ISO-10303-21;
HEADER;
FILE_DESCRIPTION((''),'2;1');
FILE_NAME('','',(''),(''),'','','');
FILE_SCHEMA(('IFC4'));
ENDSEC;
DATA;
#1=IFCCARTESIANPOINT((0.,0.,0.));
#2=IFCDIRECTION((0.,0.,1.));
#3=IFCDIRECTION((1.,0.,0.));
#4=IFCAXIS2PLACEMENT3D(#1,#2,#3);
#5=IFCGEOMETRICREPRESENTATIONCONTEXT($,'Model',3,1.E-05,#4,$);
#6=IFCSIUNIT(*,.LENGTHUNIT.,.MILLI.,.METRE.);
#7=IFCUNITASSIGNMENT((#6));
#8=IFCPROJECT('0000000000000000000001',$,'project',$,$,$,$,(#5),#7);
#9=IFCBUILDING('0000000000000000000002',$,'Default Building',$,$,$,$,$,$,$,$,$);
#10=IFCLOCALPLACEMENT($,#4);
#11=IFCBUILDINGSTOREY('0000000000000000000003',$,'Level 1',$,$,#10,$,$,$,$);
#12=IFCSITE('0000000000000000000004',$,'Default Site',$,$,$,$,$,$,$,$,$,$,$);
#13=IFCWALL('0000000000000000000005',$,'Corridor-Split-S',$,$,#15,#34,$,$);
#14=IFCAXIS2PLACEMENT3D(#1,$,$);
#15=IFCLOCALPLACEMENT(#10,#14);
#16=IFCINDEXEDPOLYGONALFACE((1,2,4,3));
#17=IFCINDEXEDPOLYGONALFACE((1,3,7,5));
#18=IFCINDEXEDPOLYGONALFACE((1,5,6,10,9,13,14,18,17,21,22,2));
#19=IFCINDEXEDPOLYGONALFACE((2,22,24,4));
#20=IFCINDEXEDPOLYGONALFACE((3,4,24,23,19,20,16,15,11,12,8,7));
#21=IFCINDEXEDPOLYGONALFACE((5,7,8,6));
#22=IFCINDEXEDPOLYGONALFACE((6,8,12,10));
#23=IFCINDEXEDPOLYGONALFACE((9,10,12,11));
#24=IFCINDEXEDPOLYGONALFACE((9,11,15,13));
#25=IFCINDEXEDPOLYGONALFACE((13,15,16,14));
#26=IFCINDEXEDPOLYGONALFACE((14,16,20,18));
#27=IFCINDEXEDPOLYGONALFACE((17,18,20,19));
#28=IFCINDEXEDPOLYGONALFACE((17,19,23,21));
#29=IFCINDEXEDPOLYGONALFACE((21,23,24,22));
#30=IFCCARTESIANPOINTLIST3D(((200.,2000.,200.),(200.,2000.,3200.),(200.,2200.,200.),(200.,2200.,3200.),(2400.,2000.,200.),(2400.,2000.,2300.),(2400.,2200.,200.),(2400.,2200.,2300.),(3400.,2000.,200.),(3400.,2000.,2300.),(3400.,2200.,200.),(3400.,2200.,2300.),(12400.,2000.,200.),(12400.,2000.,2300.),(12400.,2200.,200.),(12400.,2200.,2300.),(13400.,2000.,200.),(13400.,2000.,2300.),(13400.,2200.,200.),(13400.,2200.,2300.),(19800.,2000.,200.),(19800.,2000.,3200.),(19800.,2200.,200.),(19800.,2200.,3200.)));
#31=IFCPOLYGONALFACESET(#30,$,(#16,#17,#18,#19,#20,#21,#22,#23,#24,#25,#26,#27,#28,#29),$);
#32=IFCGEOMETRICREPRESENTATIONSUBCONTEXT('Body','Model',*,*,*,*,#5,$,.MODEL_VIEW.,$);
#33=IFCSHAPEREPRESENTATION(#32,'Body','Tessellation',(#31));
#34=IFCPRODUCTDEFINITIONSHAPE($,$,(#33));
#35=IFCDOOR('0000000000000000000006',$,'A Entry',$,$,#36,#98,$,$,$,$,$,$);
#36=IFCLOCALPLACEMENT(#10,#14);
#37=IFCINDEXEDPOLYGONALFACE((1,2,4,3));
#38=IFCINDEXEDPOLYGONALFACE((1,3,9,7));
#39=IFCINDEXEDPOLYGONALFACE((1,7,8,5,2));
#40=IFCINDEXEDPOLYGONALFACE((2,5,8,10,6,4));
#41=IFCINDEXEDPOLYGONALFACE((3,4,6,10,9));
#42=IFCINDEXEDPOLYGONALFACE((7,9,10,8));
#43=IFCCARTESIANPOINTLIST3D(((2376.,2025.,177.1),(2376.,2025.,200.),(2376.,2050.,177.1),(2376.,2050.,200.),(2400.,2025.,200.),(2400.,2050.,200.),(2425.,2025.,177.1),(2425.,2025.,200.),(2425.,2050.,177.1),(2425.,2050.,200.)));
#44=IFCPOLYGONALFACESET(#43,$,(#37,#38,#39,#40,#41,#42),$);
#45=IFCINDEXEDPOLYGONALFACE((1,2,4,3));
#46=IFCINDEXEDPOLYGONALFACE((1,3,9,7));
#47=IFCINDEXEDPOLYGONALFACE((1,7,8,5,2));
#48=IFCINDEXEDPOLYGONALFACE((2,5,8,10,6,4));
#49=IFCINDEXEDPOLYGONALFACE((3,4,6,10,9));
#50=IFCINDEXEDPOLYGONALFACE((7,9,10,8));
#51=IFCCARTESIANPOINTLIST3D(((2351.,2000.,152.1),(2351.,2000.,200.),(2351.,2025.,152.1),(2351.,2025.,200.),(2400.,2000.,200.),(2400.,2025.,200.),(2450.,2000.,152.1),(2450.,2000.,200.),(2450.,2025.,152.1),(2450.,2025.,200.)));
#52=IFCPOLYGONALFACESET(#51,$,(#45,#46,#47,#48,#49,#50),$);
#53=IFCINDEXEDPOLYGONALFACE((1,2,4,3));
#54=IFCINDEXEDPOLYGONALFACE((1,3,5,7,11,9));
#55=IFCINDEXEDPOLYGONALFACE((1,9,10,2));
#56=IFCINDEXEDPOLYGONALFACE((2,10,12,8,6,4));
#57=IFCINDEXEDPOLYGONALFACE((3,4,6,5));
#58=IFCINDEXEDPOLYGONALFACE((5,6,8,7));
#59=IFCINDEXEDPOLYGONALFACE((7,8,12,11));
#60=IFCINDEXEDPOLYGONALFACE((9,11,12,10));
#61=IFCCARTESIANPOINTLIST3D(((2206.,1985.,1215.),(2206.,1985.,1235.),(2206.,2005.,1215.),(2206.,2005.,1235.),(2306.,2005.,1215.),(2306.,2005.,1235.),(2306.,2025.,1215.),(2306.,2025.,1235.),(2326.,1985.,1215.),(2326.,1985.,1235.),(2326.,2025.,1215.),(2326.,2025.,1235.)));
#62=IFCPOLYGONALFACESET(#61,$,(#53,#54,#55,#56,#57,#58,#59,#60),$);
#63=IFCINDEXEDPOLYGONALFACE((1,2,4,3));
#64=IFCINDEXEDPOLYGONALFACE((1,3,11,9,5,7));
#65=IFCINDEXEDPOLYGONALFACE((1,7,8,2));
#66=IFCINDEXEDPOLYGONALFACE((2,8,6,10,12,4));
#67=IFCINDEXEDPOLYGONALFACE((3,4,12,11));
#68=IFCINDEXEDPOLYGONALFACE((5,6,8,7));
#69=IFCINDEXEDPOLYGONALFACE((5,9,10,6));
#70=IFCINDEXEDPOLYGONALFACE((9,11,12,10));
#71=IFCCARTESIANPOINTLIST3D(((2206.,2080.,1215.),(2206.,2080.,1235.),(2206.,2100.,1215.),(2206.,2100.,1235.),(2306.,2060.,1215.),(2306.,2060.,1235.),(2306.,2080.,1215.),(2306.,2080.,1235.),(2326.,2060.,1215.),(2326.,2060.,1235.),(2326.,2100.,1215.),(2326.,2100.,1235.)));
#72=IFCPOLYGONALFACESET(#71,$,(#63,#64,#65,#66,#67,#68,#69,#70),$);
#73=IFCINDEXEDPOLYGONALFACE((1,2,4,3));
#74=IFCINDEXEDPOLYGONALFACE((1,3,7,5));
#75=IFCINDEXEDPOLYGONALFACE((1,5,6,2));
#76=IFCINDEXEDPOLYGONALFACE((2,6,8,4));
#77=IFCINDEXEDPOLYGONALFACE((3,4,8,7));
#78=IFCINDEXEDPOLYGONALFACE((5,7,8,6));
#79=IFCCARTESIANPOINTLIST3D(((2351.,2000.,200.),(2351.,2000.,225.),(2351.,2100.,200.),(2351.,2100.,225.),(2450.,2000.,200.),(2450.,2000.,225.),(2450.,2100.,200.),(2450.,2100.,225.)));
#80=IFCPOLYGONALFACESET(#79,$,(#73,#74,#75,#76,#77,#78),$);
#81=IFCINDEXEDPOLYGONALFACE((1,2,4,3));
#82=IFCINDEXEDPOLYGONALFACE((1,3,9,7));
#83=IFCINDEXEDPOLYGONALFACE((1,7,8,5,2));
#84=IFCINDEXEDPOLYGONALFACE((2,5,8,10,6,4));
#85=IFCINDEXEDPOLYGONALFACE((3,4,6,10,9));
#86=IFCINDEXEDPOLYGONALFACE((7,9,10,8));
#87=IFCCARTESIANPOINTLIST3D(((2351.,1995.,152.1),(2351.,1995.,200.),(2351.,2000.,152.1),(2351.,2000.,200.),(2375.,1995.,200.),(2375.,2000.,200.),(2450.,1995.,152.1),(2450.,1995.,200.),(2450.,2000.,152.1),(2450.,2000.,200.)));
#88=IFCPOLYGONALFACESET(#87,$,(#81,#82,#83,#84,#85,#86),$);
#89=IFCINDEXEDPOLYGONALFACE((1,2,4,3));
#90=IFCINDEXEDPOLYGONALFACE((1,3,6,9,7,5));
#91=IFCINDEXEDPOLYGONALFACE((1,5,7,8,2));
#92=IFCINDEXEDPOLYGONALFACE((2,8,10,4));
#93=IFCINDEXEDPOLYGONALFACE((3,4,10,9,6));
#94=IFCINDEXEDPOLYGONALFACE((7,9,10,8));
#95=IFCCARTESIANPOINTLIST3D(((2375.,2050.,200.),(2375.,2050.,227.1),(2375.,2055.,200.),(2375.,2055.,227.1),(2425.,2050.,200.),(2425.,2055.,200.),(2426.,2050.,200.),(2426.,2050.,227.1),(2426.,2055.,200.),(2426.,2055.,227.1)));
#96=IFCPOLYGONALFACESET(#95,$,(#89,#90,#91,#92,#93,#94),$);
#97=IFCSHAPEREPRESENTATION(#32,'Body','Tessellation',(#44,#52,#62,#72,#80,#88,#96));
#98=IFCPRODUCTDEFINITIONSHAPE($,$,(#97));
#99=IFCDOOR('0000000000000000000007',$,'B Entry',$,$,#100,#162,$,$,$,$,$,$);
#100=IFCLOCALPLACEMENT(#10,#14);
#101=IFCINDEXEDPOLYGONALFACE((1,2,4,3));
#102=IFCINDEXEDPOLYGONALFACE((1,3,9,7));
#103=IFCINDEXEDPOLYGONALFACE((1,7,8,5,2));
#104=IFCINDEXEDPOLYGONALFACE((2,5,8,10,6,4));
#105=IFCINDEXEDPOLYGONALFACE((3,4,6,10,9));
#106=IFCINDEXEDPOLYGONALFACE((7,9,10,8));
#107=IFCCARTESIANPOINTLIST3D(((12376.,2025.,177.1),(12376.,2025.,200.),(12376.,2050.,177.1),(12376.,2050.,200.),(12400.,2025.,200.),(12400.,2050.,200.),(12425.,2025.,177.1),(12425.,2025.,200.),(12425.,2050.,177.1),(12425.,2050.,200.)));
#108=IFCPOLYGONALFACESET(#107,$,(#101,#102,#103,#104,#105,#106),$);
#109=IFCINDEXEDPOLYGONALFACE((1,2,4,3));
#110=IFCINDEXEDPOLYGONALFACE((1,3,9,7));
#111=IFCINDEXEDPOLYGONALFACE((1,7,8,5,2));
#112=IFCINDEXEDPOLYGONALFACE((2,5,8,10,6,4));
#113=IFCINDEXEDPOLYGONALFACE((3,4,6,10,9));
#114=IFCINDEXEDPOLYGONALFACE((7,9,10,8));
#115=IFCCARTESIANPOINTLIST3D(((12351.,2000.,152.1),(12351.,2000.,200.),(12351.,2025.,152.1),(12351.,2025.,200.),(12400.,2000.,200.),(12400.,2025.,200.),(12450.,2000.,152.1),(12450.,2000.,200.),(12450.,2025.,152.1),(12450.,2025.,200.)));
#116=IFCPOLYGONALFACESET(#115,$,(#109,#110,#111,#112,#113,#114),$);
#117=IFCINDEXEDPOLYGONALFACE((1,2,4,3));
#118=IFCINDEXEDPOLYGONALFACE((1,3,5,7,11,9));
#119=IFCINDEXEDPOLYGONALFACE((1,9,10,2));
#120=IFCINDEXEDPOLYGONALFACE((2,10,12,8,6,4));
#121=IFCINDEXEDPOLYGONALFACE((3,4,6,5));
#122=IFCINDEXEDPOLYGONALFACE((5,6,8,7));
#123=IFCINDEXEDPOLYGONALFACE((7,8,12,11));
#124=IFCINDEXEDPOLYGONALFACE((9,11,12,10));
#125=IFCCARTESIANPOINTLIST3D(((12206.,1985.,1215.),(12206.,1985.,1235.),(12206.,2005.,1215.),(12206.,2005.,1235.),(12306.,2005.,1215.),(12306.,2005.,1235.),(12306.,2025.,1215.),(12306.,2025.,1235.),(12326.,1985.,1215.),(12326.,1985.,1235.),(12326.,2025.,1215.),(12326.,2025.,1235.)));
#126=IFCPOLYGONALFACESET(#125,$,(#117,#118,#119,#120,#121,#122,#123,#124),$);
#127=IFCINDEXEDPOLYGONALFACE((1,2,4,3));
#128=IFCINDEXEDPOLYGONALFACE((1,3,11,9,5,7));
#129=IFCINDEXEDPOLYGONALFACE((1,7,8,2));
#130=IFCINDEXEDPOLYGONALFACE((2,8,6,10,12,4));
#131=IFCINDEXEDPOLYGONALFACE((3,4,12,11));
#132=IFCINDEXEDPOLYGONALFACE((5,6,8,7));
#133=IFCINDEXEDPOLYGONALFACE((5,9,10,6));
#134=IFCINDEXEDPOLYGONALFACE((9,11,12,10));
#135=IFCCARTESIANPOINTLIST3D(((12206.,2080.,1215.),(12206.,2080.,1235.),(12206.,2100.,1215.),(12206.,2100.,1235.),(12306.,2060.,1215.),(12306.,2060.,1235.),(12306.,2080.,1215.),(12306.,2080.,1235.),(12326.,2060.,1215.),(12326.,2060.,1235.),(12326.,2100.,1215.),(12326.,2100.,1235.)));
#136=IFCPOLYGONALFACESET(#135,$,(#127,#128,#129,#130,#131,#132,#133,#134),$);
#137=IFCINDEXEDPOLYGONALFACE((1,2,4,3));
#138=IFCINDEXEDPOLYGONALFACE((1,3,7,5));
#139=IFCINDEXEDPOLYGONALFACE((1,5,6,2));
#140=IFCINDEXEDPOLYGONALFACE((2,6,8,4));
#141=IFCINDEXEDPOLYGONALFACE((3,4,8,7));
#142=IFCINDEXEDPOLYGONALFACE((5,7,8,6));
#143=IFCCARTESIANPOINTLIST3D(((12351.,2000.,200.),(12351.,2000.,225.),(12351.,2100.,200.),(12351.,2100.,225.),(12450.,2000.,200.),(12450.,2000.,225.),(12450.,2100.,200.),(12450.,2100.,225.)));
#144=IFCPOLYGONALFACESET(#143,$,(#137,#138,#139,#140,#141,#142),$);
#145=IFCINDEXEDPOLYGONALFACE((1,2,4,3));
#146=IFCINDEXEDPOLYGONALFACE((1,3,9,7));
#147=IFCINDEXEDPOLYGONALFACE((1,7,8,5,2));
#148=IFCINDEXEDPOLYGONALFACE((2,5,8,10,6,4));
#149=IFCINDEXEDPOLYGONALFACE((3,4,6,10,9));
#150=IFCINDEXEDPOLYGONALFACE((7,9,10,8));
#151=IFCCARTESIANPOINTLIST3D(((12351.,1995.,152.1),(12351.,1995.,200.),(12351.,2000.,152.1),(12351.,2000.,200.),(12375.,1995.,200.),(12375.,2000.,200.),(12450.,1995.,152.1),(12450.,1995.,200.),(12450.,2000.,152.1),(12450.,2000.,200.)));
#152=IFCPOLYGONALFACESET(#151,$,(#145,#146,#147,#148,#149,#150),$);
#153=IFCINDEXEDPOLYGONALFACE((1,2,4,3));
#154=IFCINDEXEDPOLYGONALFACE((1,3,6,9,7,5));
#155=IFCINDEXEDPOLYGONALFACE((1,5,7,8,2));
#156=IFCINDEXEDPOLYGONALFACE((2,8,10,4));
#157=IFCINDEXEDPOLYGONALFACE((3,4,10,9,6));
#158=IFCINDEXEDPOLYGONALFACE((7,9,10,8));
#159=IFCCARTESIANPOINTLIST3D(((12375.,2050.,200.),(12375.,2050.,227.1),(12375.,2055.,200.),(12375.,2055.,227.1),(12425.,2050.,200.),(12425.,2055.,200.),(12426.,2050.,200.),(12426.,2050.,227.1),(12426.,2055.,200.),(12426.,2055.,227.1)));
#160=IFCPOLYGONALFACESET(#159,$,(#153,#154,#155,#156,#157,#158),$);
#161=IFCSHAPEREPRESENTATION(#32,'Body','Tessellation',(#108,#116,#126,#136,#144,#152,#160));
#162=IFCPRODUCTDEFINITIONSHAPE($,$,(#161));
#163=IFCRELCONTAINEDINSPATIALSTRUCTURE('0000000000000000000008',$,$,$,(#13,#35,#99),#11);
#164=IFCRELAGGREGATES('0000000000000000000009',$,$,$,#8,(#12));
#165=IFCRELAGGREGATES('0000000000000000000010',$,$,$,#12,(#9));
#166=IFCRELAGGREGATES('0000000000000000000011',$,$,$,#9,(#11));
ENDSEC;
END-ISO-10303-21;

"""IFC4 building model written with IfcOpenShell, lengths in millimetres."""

from ifc_helpers import new_model, si_unit, frame, origin_with_axes, place, context, subcontext, project, spatial, line, indexed_curve, outline, extrude, element, fill, save


model = new_model("IFC4")

# Units and contexts
model_context = context("Model", 3, precision=1e-05, world=origin_with_axes())
body_context = subcontext(model_context, "Body", "Model", "MODEL_VIEW")
ifc_project = project(units=[si_unit("LENGTHUNIT", "METRE", prefix="MILLI")], contexts=[model_context])

# Site, building, storey
site = spatial("IfcSite", under=ifc_project, Name="Default Site")
building = spatial("IfcBuilding", under=site, Name="Default Building")
storey_placement = place(None, origin_with_axes())
storey = spatial("IfcBuildingStorey", under=building, at=storey_placement, Name="Level 1")

# Wall, openings, doors
wall_1_placement = place(storey_placement, frame((0.0, 0.0, 200.0), z_axis=(0.0, 0.0, 1.0), x_axis=(1.0, 0.0, 0.0)))
wall_1 = element("IfcWall", 1, at=wall_1_placement, inside=storey, Name="Corridor-Split-S", context=body_context, shape_type="SweptSolid", body=[
    extrude(outline(indexed_curve([(200.0, 2000.0), (19800.0, 2000.0), (19800.0, 2200.0), (200.0, 2200.0), (200.0, 2000.0)])), None, (0.0, 0.0, 1.0), 3000.0),
])
opening_1_placement = place(wall_1_placement, origin_with_axes())
opening_1 = element("IfcOpeningElement", 2, at=opening_1_placement, cuts=wall_1, context=body_context, shape_type="SweptSolid", body=[
    extrude(outline(indexed_curve([(2400.0, 2000.0), (3400.0, 2000.0), (3400.0, 2200.0), (2400.0, 2200.0), (2400.0, 2000.0)])), None, (0.0, 0.0, 1.0), 2100.0),
])
opening_2_placement = place(wall_1_placement, origin_with_axes())
opening_2 = element("IfcOpeningElement", 3, at=opening_2_placement, cuts=wall_1, context=body_context, shape_type="SweptSolid", body=[
    extrude(outline(indexed_curve([(12400.0, 2000.0), (13400.0, 2000.0), (13400.0, 2200.0), (12400.0, 2200.0), (12400.0, 2000.0)])), None, (0.0, 0.0, 1.0), 2100.0),
])
door_1_placement = place(storey_placement, frame((2400.0, 2000.0, 200.0), z_axis=(0.0, 0.0, 1.0), x_axis=(1.0, 0.0, 0.0)))
door_1 = element("IfcDoor", 4, at=door_1_placement, inside=storey, Name="A Entry", context=body_context, shape_type="SweptSolid", body=[
    extrude(outline(indexed_curve([(0.0, 0.0), (0.0, 2.1), (1.0, 2.1), (1.0, 0.0), (-24.0, 0.0), (-24.0, -22.9), (25.0, -22.9), (25.0, 0.0)], segments=[line(1, 2, 3, 4, 5, 6, 7, 8, 1)])), frame((0.0, 25.0, 0.0), z_axis=(0.0, -1.0, 0.0), x_axis=(1.0, 0.0, 0.0)), (0.0, 0.0, -1.0), 25.0),
    extrude(outline(indexed_curve([(0.0, 0.0), (0.0, 2.1), (1.0, 2.1), (1.0, 0.0), (-49.0, 0.0), (-49.0, -47.9), (50.0, -47.9), (50.0, 0.0)], segments=[line(1, 2, 3, 4, 5, 6, 7, 8, 1)])), frame((0.0, 0.0, 0.0), z_axis=(0.0, -1.0, 0.0), x_axis=(1.0, 0.0, 0.0)), (0.0, 0.0, -1.0), 25.0),
    extrude(outline(indexed_curve([(0.0, 0.0), (-49.0, 0.0), (-49.0, 35.0), (0.0, 35.0)], segments=[line(1, 2, 3, 4, 1)])), frame((25.0, 25.0, 25.0), z_axis=(0.0, 0.0, 1.0), x_axis=(1.0, 0.0, 0.0)), (0.0, 0.0, 1.0), -47.9),
    extrude(outline(indexed_curve([(0.0, 0.0), (0.0, -40.0), (-120.0, -40.0), (-120.0, -20.0), (-20.0, -20.0), (-20.0, 0.0)], segments=[line(1, 2, 3, 4, 5, 6, 1)])), frame((-74.0, 25.0, 1015.0), z_axis=(0.0, 0.0, 1.0), x_axis=(1.0, 0.0, 0.0)), (0.0, 0.0, 1.0), 20.0),
    extrude(outline(indexed_curve([(0.0, 0.0), (0.0, 40.0), (-120.0, 40.0), (-120.0, 20.0), (-20.0, 20.0), (-20.0, 0.0)], segments=[line(1, 2, 3, 4, 5, 6, 1)])), frame((-74.0, 60.0, 1015.0), z_axis=(0.0, 0.0, 1.0), x_axis=(1.0, 0.0, 0.0)), (0.0, 0.0, 1.0), 20.0),
    extrude(outline(indexed_curve([(0.0, 0.0), (-99.0, 0.0), (-99.0, 100.0), (0.0, 100.0)], segments=[line(1, 2, 3, 4, 1)])), frame((50.0, 0.0, 0.0), z_axis=(0.0, 0.0, 1.0), x_axis=(1.0, 0.0, 0.0)), (0.0, 0.0, 1.0), 25.0),
    extrude(outline(indexed_curve([(0.0, 0.0), (0.0, 27.1), (51.0, 27.1), (51.0, 0.0), (-24.0, 0.0), (-24.0, -47.9), (75.0, -47.9), (75.0, 0.0)], segments=[line(1, 2, 3, 4, 5, 6, 7, 8, 1)])), frame((-25.0, -5.0, 0.0), z_axis=(0.0, -1.0, 0.0), x_axis=(1.0, 0.0, 0.0)), (0.0, 0.0, -1.0), 5.0),
    extrude(outline(indexed_curve([(0.0, 0.0), (0.0, 27.1), (51.0, 27.1), (51.0, 0.0), (1.0, 0.0), (1.0, -22.9), (50.0, -22.9), (50.0, 0.0)], segments=[line(1, 2, 3, 4, 5, 6, 7, 8, 1)])), frame((-25.0, 50.0, 0.0), z_axis=(0.0, -1.0, 0.0), x_axis=(1.0, 0.0, 0.0)), (0.0, 0.0, -1.0), 5.0),
])
fill(opening_1, door_1)
door_2_placement = place(storey_placement, frame((12400.0, 2000.0, 200.0), z_axis=(0.0, 0.0, 1.0), x_axis=(1.0, 0.0, 0.0)))
door_2 = element("IfcDoor", 5, at=door_2_placement, inside=storey, Name="B Entry", context=body_context, shape_type="SweptSolid", body=[
    extrude(outline(indexed_curve([(0.0, 0.0), (0.0, 2.1), (1.0, 2.1), (1.0, 0.0), (-24.0, 0.0), (-24.0, -22.9), (25.0, -22.9), (25.0, 0.0)], segments=[line(1, 2, 3, 4, 5, 6, 7, 8, 1)])), frame((0.0, 25.0, 0.0), z_axis=(0.0, -1.0, 0.0), x_axis=(1.0, 0.0, 0.0)), (0.0, 0.0, -1.0), 25.0),
    extrude(outline(indexed_curve([(0.0, 0.0), (0.0, 2.1), (1.0, 2.1), (1.0, 0.0), (-49.0, 0.0), (-49.0, -47.9), (50.0, -47.9), (50.0, 0.0)], segments=[line(1, 2, 3, 4, 5, 6, 7, 8, 1)])), frame((0.0, 0.0, 0.0), z_axis=(0.0, -1.0, 0.0), x_axis=(1.0, 0.0, 0.0)), (0.0, 0.0, -1.0), 25.0),
    extrude(outline(indexed_curve([(0.0, 0.0), (-49.0, 0.0), (-49.0, 35.0), (0.0, 35.0)], segments=[line(1, 2, 3, 4, 1)])), frame((25.0, 25.0, 25.0), z_axis=(0.0, 0.0, 1.0), x_axis=(1.0, 0.0, 0.0)), (0.0, 0.0, 1.0), -47.9),
    extrude(outline(indexed_curve([(0.0, 0.0), (0.0, -40.0), (-120.0, -40.0), (-120.0, -20.0), (-20.0, -20.0), (-20.0, 0.0)], segments=[line(1, 2, 3, 4, 5, 6, 1)])), frame((-74.0, 25.0, 1015.0), z_axis=(0.0, 0.0, 1.0), x_axis=(1.0, 0.0, 0.0)), (0.0, 0.0, 1.0), 20.0),
    extrude(outline(indexed_curve([(0.0, 0.0), (0.0, 40.0), (-120.0, 40.0), (-120.0, 20.0), (-20.0, 20.0), (-20.0, 0.0)], segments=[line(1, 2, 3, 4, 5, 6, 1)])), frame((-74.0, 60.0, 1015.0), z_axis=(0.0, 0.0, 1.0), x_axis=(1.0, 0.0, 0.0)), (0.0, 0.0, 1.0), 20.0),
    extrude(outline(indexed_curve([(0.0, 0.0), (-99.0, 0.0), (-99.0, 100.0), (0.0, 100.0)], segments=[line(1, 2, 3, 4, 1)])), frame((50.0, 0.0, 0.0), z_axis=(0.0, 0.0, 1.0), x_axis=(1.0, 0.0, 0.0)), (0.0, 0.0, 1.0), 25.0),
    extrude(outline(indexed_curve([(0.0, 0.0), (0.0, 27.1), (51.0, 27.1), (51.0, 0.0), (-24.0, 0.0), (-24.0, -47.9), (75.0, -47.9), (75.0, 0.0)], segments=[line(1, 2, 3, 4, 5, 6, 7, 8, 1)])), frame((-25.0, -5.0, 0.0), z_axis=(0.0, -1.0, 0.0), x_axis=(1.0, 0.0, 0.0)), (0.0, 0.0, -1.0), 5.0),
    extrude(outline(indexed_curve([(0.0, 0.0), (0.0, 27.1), (51.0, 27.1), (51.0, 0.0), (1.0, 0.0), (1.0, -22.9), (50.0, -22.9), (50.0, 0.0)], segments=[line(1, 2, 3, 4, 5, 6, 7, 8, 1)])), frame((-25.0, 50.0, 0.0), z_axis=(0.0, -1.0, 0.0), x_axis=(1.0, 0.0, 0.0)), (0.0, 0.0, -1.0), 5.0),
])
fill(opening_2, door_2)

save(model, "model.ifc")
